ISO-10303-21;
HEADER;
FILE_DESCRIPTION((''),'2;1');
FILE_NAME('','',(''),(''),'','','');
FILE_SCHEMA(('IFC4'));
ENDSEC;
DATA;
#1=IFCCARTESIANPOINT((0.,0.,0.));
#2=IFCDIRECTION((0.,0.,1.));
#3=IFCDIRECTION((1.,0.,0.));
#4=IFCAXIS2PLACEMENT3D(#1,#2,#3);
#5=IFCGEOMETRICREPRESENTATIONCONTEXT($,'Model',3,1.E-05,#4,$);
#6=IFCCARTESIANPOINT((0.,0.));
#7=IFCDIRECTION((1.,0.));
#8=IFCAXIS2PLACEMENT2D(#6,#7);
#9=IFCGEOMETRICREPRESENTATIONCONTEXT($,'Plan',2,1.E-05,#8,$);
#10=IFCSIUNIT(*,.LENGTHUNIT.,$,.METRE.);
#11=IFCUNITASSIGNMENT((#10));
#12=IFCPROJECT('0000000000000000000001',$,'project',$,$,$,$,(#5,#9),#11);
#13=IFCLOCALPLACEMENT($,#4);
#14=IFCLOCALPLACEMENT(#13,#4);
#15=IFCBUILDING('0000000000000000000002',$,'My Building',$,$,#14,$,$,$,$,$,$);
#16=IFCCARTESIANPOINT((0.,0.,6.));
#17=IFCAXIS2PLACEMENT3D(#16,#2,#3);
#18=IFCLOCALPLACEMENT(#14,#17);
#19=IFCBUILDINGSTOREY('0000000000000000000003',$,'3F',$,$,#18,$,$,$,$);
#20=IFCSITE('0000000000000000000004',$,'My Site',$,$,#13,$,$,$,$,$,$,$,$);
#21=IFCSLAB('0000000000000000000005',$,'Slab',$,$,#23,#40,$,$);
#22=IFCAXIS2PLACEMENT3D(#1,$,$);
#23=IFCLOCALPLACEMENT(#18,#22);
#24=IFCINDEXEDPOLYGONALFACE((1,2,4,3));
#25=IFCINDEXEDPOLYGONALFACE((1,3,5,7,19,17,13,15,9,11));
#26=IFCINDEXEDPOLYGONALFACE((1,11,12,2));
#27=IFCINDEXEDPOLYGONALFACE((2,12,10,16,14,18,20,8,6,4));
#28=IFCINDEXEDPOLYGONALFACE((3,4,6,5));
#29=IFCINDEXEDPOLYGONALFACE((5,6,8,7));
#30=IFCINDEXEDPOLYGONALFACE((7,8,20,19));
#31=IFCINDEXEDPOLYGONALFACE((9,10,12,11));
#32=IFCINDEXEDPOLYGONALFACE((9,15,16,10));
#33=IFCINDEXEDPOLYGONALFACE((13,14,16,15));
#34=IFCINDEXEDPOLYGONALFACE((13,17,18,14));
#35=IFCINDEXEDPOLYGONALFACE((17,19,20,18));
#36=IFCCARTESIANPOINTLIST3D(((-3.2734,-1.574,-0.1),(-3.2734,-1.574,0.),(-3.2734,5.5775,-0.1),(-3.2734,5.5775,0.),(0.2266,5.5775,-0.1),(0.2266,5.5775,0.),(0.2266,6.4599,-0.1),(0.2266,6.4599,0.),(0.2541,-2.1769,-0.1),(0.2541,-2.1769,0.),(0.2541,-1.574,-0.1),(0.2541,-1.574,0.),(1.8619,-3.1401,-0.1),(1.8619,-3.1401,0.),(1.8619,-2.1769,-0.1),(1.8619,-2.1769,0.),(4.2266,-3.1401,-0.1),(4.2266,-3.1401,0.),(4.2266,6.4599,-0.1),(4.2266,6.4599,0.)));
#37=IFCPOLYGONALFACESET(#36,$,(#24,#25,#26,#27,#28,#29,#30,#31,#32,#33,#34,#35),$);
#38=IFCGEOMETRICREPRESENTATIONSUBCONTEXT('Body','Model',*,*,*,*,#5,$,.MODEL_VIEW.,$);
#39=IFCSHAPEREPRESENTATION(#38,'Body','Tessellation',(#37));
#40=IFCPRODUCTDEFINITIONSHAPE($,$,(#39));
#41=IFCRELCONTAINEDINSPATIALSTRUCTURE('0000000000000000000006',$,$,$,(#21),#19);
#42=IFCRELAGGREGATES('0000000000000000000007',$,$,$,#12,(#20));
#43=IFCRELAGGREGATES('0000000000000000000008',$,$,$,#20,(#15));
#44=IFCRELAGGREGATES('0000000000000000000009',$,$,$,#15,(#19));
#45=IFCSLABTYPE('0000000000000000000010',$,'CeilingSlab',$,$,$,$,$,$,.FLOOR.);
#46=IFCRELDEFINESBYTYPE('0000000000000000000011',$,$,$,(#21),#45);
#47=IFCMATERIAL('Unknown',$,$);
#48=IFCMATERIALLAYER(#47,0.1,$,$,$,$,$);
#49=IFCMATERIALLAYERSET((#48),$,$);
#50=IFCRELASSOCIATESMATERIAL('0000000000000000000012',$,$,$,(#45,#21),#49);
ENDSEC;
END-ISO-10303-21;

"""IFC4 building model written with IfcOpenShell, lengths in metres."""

from ifc_helpers import new_model, si_unit, frame, origin_with_axes, origin_2d_with_axis, place, context, subcontext, project, spatial, indexed_curve, outline, extrude, material, layer, layer_set, layer_usage, type_object, element, save


model = new_model("IFC4")

# Units and contexts
model_context = context("Model", 3, precision=1e-05, world=origin_with_axes())
plan_context = context("Plan", 2, precision=1e-05, world=origin_2d_with_axis())
body_context = subcontext(model_context, "Body", "Model", "MODEL_VIEW")
ifc_project = project(units=[si_unit("LENGTHUNIT", "METRE")], contexts=[model_context, plan_context])

# Site, building, storey
site_placement = place(None, origin_with_axes())
site = spatial("IfcSite", under=ifc_project, at=site_placement, Name="My Site")
building_placement = place(site_placement, origin_with_axes())
building = spatial("IfcBuilding", under=site, at=building_placement, Name="My Building")
storey_placement = place(building_placement, frame((0.0, 0.0, 6.0), z_axis=(0.0, 0.0, 1.0), x_axis=(1.0, 0.0, 0.0)))
storey = spatial("IfcBuildingStorey", under=building, at=storey_placement, Name="3F")

# Slab
ifc_material = material(Name="Unknown")
ifc_layer = layer(ifc_material, 0.1)
ifc_layer_set = layer_set([ifc_layer])
ifc_layer_usage = layer_usage(ifc_layer_set, "AXIS3", "POSITIVE", -0.1)
slab_type = type_object("IfcSlabType", Name="CeilingSlab", PredefinedType="FLOOR", material=ifc_layer_set)
slab_placement = place(storey_placement, frame((4.2266, 6.4599, 0.0), z_axis=(0.0, 0.0, 1.0), x_axis=(1.0, 0.0, 0.0)))
element("IfcSlab", 1, at=slab_placement, inside=storey, type_object=slab_type, material=ifc_layer_usage, Name="Slab", context=body_context, shape_type="SweptSolid", body=[
    extrude(outline(indexed_curve([(0.0, 0.0), (-4.0, 0.0), (-4.0, -0.8824), (-7.5, -0.8824), (-7.5, -8.0339), (-3.9725, -8.0339), (-3.9725, -8.6368), (-2.3647, -8.6368), (-2.3647, -9.6), (0.0, -9.6), (0.0, 0.0)])), frame((0.0, 0.0, -0.1), z_axis=(0.0, 0.0, 1.0), x_axis=(1.0, 0.0, 0.0)), (0.0, 0.0, 1.0), 0.1),
])

save(model, "model.ifc")
